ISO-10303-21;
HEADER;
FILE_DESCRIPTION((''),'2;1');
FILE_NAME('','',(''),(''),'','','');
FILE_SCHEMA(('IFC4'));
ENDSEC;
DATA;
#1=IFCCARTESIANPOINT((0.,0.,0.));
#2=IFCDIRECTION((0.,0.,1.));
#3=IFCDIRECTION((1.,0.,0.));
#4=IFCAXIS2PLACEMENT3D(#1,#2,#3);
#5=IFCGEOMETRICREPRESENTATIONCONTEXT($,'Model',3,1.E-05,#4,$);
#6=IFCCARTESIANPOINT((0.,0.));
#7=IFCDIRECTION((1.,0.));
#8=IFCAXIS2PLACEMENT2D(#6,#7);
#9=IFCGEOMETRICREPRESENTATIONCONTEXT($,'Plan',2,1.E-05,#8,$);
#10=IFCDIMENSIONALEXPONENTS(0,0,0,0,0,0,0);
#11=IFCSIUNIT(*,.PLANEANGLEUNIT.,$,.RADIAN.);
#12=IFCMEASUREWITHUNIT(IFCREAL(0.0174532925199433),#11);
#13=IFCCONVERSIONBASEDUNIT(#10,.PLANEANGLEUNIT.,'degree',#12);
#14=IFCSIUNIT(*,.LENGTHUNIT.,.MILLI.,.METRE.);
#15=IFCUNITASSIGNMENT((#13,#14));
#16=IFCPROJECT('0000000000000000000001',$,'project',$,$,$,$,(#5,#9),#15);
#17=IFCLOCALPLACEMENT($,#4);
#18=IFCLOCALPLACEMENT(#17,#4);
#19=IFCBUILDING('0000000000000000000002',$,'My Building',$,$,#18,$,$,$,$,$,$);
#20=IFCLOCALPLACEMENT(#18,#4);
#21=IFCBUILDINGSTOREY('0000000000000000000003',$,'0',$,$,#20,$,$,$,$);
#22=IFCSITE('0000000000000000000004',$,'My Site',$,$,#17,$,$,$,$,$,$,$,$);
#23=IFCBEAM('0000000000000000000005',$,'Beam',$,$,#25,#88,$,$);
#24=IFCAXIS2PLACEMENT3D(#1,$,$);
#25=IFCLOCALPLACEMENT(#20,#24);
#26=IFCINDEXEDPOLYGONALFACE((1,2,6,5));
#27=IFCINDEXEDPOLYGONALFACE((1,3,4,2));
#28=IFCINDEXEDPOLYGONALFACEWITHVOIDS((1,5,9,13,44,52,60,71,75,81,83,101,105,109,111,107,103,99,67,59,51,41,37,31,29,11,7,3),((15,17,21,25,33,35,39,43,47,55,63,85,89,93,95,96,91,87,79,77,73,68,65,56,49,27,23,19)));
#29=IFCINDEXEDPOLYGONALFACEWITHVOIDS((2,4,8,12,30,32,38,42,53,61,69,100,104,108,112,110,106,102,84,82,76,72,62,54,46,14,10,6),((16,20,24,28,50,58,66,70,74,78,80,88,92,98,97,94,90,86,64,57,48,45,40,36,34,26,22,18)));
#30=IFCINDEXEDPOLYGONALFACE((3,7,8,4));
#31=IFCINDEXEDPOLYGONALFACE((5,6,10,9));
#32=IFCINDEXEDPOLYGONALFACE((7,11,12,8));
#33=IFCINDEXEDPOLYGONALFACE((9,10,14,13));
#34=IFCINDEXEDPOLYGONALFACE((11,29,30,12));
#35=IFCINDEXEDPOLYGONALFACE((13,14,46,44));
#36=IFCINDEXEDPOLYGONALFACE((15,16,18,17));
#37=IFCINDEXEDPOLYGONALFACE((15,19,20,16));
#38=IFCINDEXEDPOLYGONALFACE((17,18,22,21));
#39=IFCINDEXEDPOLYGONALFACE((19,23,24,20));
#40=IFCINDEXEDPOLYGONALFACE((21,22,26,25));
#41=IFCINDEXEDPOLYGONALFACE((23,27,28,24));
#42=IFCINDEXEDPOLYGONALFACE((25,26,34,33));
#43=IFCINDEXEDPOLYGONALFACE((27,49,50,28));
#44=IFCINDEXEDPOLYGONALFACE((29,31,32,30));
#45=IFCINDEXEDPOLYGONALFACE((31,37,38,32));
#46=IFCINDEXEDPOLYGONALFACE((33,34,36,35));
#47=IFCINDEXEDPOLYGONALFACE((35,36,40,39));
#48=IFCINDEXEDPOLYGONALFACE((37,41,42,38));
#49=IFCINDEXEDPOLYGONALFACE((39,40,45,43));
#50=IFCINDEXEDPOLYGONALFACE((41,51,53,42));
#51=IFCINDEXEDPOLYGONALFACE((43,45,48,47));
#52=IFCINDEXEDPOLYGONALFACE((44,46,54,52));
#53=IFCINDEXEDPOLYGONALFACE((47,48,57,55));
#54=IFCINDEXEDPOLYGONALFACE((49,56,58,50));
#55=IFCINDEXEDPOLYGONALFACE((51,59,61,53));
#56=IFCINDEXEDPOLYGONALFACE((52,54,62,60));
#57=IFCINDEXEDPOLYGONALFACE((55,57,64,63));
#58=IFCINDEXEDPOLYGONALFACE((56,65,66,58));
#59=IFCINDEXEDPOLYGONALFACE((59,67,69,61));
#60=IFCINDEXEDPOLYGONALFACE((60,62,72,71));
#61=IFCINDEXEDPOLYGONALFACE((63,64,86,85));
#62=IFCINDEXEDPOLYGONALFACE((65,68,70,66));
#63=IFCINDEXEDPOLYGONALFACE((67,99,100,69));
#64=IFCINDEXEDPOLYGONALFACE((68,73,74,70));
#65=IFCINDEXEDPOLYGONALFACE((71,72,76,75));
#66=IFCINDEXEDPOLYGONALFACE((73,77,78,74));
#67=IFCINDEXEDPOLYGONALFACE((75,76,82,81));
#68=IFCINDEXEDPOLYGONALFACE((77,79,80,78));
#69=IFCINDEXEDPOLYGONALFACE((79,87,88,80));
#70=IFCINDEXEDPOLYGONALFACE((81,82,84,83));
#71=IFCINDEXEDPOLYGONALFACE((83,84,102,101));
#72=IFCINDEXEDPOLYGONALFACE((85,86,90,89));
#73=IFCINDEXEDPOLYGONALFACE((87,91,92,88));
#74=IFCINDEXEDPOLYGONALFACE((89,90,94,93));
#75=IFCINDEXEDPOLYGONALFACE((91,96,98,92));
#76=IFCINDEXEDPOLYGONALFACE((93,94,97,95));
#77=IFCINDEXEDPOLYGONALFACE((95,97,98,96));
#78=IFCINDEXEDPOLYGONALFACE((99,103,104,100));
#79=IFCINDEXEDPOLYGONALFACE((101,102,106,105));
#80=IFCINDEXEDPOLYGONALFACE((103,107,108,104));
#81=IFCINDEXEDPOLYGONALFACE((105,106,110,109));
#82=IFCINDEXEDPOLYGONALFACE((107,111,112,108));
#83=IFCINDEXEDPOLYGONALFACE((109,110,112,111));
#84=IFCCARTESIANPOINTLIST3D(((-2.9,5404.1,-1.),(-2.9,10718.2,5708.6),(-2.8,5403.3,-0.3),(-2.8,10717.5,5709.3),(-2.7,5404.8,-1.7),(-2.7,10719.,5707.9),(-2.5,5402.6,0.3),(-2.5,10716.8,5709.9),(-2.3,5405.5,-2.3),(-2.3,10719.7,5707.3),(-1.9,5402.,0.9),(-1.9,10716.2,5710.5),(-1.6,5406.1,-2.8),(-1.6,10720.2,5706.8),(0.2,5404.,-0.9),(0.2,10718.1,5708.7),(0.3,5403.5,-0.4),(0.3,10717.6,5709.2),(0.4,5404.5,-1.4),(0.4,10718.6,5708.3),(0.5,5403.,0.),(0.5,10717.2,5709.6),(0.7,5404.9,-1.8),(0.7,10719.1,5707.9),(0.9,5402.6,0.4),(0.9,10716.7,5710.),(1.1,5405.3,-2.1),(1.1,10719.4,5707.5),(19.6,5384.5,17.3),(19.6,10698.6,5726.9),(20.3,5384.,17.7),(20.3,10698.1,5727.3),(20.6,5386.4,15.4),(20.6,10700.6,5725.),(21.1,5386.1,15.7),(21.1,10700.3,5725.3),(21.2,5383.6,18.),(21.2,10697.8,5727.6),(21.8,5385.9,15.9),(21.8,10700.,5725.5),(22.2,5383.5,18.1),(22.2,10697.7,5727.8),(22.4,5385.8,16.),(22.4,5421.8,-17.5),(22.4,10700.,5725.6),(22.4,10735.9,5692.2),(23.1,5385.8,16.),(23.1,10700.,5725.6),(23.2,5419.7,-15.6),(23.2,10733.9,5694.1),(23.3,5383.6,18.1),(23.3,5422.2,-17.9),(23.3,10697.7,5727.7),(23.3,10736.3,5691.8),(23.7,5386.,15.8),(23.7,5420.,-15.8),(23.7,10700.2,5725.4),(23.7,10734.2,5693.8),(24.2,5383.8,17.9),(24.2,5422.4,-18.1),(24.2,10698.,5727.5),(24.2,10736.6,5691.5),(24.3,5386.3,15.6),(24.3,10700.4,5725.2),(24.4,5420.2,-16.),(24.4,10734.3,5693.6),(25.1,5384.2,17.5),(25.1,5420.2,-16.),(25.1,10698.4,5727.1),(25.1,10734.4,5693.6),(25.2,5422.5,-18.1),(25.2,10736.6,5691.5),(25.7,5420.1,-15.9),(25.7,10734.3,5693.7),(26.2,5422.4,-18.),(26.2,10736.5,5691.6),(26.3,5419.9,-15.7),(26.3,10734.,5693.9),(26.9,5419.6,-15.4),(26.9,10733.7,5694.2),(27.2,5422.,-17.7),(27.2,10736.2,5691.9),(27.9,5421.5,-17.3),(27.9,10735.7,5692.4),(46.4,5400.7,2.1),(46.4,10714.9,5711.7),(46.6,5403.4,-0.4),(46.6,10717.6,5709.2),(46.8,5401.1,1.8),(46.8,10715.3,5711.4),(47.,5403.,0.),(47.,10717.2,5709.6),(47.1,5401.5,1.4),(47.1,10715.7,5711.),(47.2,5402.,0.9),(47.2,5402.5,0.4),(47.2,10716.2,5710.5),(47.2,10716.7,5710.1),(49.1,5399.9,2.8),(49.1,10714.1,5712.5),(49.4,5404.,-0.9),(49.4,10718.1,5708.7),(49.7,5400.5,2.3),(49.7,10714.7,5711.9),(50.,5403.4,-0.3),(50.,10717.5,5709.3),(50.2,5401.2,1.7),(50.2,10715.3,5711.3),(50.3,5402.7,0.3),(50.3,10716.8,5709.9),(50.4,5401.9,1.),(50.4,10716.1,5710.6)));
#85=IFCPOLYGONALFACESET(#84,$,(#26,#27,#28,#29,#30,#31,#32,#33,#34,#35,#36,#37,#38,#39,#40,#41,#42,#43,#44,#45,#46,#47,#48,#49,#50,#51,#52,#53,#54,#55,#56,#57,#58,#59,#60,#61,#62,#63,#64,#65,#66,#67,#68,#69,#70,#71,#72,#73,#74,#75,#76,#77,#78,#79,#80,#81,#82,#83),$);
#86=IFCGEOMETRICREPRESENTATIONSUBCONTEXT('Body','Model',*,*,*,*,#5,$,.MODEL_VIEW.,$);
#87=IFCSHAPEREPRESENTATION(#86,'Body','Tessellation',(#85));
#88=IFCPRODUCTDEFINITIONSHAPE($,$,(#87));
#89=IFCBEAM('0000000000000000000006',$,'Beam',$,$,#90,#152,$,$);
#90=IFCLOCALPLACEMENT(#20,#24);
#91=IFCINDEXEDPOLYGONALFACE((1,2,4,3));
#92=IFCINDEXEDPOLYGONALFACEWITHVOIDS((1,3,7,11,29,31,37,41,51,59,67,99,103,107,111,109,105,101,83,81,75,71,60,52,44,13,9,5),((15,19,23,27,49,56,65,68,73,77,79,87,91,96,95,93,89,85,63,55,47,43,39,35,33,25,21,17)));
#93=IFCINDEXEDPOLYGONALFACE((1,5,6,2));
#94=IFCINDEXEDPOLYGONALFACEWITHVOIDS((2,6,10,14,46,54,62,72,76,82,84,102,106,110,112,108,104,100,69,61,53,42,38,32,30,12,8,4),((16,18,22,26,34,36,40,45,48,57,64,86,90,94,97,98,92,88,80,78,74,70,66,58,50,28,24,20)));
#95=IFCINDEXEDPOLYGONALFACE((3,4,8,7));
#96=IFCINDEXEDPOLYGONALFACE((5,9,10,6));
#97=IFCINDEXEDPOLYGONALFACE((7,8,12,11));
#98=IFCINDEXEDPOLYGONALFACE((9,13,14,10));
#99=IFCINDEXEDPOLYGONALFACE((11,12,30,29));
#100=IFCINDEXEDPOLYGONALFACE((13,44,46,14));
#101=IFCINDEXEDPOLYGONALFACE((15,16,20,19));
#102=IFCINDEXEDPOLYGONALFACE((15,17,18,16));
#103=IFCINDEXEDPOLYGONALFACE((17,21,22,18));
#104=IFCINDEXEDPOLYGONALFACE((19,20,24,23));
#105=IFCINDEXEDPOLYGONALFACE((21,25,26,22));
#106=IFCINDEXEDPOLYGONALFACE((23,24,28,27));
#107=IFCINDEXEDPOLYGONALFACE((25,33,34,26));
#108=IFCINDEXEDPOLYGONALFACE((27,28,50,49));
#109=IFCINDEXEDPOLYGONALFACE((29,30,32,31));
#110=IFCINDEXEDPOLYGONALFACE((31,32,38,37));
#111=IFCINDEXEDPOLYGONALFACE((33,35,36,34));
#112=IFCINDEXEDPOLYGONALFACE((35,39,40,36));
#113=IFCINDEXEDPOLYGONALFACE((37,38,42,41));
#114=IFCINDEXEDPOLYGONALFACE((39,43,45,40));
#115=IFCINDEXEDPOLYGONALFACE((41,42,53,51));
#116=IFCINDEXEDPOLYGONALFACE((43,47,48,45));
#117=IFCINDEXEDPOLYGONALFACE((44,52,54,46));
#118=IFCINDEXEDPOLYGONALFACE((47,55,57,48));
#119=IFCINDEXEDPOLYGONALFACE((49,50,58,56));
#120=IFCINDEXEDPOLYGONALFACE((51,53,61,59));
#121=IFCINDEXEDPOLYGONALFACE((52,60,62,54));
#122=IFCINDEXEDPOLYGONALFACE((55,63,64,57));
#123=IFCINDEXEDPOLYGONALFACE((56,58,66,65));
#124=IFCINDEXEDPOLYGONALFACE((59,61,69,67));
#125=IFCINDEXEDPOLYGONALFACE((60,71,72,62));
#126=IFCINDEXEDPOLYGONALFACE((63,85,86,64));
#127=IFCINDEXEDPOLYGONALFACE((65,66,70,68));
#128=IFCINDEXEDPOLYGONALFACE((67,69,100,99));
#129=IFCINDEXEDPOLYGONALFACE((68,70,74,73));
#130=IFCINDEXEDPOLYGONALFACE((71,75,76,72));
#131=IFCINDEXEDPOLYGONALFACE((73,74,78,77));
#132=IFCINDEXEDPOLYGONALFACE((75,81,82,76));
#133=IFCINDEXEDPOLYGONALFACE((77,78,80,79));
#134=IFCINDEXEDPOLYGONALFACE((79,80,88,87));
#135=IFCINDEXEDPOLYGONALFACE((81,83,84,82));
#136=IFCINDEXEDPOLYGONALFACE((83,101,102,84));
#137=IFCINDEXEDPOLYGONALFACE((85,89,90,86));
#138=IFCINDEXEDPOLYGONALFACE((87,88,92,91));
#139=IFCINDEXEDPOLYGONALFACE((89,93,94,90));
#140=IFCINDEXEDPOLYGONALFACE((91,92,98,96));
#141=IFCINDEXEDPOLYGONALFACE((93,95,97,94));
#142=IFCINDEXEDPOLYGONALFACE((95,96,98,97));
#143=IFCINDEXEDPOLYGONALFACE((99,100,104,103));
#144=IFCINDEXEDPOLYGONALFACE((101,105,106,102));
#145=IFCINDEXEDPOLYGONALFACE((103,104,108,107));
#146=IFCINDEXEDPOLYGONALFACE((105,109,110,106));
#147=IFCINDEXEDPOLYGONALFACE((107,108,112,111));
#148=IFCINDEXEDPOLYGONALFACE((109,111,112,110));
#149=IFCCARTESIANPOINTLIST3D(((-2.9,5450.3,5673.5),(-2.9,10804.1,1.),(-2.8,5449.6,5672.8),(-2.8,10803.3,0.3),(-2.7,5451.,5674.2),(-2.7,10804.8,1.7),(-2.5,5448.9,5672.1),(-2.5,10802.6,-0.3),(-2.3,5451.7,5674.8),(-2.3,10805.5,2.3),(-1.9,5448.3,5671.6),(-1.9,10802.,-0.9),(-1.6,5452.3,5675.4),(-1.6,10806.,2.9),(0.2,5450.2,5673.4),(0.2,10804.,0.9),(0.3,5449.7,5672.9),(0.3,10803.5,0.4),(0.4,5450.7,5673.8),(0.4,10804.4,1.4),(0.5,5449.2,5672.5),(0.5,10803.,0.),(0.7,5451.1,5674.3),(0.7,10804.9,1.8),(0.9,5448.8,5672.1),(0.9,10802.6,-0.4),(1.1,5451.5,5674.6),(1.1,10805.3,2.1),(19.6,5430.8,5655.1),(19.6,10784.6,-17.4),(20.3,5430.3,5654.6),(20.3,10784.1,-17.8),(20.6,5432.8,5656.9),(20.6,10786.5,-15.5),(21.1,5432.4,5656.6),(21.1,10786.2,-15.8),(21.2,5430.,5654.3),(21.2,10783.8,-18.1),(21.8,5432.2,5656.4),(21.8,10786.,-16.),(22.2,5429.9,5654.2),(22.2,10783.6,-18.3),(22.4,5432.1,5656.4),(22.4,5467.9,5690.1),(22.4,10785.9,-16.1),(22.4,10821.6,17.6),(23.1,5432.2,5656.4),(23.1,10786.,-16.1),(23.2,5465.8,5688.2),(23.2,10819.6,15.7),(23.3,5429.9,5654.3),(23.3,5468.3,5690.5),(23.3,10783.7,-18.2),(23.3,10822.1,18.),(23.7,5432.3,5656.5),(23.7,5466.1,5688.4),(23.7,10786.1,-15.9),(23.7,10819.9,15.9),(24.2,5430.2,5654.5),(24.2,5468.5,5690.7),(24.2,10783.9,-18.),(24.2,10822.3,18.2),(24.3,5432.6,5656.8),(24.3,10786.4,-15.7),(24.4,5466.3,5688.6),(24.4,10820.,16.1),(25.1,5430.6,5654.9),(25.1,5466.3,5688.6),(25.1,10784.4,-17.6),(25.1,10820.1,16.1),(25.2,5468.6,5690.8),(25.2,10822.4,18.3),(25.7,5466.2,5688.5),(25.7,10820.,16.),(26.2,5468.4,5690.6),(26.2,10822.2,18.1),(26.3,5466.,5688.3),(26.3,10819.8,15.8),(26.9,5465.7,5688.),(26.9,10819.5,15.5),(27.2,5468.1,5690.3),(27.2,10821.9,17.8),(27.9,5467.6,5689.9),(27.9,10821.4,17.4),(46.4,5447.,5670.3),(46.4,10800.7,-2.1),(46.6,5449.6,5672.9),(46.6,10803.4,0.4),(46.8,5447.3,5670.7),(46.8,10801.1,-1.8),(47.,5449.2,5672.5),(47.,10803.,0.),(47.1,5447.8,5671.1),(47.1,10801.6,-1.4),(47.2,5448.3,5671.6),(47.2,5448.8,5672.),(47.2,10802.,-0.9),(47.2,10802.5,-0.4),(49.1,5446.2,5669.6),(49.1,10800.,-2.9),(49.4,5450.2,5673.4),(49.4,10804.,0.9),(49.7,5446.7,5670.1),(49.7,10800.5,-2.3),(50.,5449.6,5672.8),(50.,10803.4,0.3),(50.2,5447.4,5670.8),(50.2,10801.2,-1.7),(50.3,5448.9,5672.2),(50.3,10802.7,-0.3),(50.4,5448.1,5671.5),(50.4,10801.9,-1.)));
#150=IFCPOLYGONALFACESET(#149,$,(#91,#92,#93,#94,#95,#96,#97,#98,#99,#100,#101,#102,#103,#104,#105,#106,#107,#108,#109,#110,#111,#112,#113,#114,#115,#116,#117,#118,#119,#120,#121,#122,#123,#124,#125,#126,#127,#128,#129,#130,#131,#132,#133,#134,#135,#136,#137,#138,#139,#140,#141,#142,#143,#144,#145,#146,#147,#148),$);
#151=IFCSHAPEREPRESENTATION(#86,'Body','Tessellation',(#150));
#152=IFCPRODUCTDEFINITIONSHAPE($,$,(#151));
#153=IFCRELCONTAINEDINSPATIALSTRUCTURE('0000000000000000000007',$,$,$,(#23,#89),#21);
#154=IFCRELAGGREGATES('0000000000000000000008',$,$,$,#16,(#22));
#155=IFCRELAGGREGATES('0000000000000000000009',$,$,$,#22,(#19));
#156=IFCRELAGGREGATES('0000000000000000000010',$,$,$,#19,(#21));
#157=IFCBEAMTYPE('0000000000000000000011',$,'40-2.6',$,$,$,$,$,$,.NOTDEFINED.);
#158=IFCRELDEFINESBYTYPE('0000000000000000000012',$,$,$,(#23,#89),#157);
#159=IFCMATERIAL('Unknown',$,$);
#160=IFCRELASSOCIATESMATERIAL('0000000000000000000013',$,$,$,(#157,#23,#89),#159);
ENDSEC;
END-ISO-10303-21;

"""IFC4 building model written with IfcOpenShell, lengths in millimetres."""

from ifc_helpers import new_model, entity, si_unit, converted_unit, frame, origin_with_axes, origin_2d_with_axis, place, context, subcontext, project, spatial, hollow_rectangle, extrude, material, material_profile, profile_set, profile_usage, type_object, element, save


model = new_model("IFC4")

# Units and contexts
model_context = context("Model", 3, precision=1e-05, world=origin_with_axes())
plan_context = context("Plan", 2, precision=1e-05, world=origin_2d_with_axis())
body_context = subcontext(model_context, "Body", "Model", "MODEL_VIEW")
ifc_project = project(units=[converted_unit("PLANEANGLEUNIT", "degree", entity("IfcReal", 0.0174532925199433), si_unit("PLANEANGLEUNIT", "RADIAN"), dimensions=[0, 0, 0, 0, 0, 0, 0]), si_unit("LENGTHUNIT", "METRE", prefix="MILLI")], contexts=[model_context, plan_context])

# Site, building, storey
site_placement = place(None, origin_with_axes())
site = spatial("IfcSite", under=ifc_project, at=site_placement, Name="My Site")
building_placement = place(site_placement, origin_with_axes())
building = spatial("IfcBuilding", under=site, at=building_placement, Name="My Building")
storey_placement = place(building_placement, origin_with_axes())
storey = spatial("IfcBuildingStorey", under=building, at=storey_placement, Name="0")

# Shared definitions
ifc_material = material(Name="Unknown")

# Beams
ifc_material_profile_1 = material_profile(ifc_material, hollow_rectangle(XDim=40.0, YDim=40.0, WallThickness=2.6, InnerFilletRadius=2.6, OuterFilletRadius=3.9))
ifc_profile_set_1 = profile_set([ifc_material_profile_1])
beam_type = type_object("IfcBeamType", Name="40-2.6", PredefinedType="NOTDEFINED", material=ifc_profile_set_1)
ifc_profile_usage_1 = profile_usage(ifc_profile_set_1, cardinal=5)
beam_1_placement = place(storey_placement, frame((23.7, 5403.0, 0.0), z_axis=(0.0, 0.681302, 0.732003), x_axis=(-0.666409, 0.545771, -0.507969)))
element("IfcBeam", 1, at=beam_1_placement, inside=storey, type_object=beam_type, material=ifc_profile_usage_1, Name="Beam", context=body_context, shape_type="SweptSolid", body=[
    extrude(hollow_rectangle(XDim=40.0, YDim=40.0, WallThickness=2.6, InnerFilletRadius=2.6, OuterFilletRadius=3.9), origin_with_axes(), (0.0, 0.0, 1.0), 7800.0),
])
ifc_profile_usage_2 = profile_usage(ifc_profile_set_1, cardinal=5)
beam_2_placement = place(storey_placement, frame((23.7, 10803.0, 0.0), z_axis=(0.0, -0.686382, 0.727241), x_axis=(-0.666409, 0.542221, 0.511757)))
element("IfcBeam", 2, at=beam_2_placement, inside=storey, type_object=beam_type, material=ifc_profile_usage_2, Name="Beam", context=body_context, shape_type="SweptSolid", body=[
    extrude(hollow_rectangle(XDim=40.0, YDim=40.0, WallThickness=2.6, InnerFilletRadius=2.6, OuterFilletRadius=3.9), origin_with_axes(), (0.0, 0.0, 1.0), 7800.0),
])

save(model, "model.ifc")
